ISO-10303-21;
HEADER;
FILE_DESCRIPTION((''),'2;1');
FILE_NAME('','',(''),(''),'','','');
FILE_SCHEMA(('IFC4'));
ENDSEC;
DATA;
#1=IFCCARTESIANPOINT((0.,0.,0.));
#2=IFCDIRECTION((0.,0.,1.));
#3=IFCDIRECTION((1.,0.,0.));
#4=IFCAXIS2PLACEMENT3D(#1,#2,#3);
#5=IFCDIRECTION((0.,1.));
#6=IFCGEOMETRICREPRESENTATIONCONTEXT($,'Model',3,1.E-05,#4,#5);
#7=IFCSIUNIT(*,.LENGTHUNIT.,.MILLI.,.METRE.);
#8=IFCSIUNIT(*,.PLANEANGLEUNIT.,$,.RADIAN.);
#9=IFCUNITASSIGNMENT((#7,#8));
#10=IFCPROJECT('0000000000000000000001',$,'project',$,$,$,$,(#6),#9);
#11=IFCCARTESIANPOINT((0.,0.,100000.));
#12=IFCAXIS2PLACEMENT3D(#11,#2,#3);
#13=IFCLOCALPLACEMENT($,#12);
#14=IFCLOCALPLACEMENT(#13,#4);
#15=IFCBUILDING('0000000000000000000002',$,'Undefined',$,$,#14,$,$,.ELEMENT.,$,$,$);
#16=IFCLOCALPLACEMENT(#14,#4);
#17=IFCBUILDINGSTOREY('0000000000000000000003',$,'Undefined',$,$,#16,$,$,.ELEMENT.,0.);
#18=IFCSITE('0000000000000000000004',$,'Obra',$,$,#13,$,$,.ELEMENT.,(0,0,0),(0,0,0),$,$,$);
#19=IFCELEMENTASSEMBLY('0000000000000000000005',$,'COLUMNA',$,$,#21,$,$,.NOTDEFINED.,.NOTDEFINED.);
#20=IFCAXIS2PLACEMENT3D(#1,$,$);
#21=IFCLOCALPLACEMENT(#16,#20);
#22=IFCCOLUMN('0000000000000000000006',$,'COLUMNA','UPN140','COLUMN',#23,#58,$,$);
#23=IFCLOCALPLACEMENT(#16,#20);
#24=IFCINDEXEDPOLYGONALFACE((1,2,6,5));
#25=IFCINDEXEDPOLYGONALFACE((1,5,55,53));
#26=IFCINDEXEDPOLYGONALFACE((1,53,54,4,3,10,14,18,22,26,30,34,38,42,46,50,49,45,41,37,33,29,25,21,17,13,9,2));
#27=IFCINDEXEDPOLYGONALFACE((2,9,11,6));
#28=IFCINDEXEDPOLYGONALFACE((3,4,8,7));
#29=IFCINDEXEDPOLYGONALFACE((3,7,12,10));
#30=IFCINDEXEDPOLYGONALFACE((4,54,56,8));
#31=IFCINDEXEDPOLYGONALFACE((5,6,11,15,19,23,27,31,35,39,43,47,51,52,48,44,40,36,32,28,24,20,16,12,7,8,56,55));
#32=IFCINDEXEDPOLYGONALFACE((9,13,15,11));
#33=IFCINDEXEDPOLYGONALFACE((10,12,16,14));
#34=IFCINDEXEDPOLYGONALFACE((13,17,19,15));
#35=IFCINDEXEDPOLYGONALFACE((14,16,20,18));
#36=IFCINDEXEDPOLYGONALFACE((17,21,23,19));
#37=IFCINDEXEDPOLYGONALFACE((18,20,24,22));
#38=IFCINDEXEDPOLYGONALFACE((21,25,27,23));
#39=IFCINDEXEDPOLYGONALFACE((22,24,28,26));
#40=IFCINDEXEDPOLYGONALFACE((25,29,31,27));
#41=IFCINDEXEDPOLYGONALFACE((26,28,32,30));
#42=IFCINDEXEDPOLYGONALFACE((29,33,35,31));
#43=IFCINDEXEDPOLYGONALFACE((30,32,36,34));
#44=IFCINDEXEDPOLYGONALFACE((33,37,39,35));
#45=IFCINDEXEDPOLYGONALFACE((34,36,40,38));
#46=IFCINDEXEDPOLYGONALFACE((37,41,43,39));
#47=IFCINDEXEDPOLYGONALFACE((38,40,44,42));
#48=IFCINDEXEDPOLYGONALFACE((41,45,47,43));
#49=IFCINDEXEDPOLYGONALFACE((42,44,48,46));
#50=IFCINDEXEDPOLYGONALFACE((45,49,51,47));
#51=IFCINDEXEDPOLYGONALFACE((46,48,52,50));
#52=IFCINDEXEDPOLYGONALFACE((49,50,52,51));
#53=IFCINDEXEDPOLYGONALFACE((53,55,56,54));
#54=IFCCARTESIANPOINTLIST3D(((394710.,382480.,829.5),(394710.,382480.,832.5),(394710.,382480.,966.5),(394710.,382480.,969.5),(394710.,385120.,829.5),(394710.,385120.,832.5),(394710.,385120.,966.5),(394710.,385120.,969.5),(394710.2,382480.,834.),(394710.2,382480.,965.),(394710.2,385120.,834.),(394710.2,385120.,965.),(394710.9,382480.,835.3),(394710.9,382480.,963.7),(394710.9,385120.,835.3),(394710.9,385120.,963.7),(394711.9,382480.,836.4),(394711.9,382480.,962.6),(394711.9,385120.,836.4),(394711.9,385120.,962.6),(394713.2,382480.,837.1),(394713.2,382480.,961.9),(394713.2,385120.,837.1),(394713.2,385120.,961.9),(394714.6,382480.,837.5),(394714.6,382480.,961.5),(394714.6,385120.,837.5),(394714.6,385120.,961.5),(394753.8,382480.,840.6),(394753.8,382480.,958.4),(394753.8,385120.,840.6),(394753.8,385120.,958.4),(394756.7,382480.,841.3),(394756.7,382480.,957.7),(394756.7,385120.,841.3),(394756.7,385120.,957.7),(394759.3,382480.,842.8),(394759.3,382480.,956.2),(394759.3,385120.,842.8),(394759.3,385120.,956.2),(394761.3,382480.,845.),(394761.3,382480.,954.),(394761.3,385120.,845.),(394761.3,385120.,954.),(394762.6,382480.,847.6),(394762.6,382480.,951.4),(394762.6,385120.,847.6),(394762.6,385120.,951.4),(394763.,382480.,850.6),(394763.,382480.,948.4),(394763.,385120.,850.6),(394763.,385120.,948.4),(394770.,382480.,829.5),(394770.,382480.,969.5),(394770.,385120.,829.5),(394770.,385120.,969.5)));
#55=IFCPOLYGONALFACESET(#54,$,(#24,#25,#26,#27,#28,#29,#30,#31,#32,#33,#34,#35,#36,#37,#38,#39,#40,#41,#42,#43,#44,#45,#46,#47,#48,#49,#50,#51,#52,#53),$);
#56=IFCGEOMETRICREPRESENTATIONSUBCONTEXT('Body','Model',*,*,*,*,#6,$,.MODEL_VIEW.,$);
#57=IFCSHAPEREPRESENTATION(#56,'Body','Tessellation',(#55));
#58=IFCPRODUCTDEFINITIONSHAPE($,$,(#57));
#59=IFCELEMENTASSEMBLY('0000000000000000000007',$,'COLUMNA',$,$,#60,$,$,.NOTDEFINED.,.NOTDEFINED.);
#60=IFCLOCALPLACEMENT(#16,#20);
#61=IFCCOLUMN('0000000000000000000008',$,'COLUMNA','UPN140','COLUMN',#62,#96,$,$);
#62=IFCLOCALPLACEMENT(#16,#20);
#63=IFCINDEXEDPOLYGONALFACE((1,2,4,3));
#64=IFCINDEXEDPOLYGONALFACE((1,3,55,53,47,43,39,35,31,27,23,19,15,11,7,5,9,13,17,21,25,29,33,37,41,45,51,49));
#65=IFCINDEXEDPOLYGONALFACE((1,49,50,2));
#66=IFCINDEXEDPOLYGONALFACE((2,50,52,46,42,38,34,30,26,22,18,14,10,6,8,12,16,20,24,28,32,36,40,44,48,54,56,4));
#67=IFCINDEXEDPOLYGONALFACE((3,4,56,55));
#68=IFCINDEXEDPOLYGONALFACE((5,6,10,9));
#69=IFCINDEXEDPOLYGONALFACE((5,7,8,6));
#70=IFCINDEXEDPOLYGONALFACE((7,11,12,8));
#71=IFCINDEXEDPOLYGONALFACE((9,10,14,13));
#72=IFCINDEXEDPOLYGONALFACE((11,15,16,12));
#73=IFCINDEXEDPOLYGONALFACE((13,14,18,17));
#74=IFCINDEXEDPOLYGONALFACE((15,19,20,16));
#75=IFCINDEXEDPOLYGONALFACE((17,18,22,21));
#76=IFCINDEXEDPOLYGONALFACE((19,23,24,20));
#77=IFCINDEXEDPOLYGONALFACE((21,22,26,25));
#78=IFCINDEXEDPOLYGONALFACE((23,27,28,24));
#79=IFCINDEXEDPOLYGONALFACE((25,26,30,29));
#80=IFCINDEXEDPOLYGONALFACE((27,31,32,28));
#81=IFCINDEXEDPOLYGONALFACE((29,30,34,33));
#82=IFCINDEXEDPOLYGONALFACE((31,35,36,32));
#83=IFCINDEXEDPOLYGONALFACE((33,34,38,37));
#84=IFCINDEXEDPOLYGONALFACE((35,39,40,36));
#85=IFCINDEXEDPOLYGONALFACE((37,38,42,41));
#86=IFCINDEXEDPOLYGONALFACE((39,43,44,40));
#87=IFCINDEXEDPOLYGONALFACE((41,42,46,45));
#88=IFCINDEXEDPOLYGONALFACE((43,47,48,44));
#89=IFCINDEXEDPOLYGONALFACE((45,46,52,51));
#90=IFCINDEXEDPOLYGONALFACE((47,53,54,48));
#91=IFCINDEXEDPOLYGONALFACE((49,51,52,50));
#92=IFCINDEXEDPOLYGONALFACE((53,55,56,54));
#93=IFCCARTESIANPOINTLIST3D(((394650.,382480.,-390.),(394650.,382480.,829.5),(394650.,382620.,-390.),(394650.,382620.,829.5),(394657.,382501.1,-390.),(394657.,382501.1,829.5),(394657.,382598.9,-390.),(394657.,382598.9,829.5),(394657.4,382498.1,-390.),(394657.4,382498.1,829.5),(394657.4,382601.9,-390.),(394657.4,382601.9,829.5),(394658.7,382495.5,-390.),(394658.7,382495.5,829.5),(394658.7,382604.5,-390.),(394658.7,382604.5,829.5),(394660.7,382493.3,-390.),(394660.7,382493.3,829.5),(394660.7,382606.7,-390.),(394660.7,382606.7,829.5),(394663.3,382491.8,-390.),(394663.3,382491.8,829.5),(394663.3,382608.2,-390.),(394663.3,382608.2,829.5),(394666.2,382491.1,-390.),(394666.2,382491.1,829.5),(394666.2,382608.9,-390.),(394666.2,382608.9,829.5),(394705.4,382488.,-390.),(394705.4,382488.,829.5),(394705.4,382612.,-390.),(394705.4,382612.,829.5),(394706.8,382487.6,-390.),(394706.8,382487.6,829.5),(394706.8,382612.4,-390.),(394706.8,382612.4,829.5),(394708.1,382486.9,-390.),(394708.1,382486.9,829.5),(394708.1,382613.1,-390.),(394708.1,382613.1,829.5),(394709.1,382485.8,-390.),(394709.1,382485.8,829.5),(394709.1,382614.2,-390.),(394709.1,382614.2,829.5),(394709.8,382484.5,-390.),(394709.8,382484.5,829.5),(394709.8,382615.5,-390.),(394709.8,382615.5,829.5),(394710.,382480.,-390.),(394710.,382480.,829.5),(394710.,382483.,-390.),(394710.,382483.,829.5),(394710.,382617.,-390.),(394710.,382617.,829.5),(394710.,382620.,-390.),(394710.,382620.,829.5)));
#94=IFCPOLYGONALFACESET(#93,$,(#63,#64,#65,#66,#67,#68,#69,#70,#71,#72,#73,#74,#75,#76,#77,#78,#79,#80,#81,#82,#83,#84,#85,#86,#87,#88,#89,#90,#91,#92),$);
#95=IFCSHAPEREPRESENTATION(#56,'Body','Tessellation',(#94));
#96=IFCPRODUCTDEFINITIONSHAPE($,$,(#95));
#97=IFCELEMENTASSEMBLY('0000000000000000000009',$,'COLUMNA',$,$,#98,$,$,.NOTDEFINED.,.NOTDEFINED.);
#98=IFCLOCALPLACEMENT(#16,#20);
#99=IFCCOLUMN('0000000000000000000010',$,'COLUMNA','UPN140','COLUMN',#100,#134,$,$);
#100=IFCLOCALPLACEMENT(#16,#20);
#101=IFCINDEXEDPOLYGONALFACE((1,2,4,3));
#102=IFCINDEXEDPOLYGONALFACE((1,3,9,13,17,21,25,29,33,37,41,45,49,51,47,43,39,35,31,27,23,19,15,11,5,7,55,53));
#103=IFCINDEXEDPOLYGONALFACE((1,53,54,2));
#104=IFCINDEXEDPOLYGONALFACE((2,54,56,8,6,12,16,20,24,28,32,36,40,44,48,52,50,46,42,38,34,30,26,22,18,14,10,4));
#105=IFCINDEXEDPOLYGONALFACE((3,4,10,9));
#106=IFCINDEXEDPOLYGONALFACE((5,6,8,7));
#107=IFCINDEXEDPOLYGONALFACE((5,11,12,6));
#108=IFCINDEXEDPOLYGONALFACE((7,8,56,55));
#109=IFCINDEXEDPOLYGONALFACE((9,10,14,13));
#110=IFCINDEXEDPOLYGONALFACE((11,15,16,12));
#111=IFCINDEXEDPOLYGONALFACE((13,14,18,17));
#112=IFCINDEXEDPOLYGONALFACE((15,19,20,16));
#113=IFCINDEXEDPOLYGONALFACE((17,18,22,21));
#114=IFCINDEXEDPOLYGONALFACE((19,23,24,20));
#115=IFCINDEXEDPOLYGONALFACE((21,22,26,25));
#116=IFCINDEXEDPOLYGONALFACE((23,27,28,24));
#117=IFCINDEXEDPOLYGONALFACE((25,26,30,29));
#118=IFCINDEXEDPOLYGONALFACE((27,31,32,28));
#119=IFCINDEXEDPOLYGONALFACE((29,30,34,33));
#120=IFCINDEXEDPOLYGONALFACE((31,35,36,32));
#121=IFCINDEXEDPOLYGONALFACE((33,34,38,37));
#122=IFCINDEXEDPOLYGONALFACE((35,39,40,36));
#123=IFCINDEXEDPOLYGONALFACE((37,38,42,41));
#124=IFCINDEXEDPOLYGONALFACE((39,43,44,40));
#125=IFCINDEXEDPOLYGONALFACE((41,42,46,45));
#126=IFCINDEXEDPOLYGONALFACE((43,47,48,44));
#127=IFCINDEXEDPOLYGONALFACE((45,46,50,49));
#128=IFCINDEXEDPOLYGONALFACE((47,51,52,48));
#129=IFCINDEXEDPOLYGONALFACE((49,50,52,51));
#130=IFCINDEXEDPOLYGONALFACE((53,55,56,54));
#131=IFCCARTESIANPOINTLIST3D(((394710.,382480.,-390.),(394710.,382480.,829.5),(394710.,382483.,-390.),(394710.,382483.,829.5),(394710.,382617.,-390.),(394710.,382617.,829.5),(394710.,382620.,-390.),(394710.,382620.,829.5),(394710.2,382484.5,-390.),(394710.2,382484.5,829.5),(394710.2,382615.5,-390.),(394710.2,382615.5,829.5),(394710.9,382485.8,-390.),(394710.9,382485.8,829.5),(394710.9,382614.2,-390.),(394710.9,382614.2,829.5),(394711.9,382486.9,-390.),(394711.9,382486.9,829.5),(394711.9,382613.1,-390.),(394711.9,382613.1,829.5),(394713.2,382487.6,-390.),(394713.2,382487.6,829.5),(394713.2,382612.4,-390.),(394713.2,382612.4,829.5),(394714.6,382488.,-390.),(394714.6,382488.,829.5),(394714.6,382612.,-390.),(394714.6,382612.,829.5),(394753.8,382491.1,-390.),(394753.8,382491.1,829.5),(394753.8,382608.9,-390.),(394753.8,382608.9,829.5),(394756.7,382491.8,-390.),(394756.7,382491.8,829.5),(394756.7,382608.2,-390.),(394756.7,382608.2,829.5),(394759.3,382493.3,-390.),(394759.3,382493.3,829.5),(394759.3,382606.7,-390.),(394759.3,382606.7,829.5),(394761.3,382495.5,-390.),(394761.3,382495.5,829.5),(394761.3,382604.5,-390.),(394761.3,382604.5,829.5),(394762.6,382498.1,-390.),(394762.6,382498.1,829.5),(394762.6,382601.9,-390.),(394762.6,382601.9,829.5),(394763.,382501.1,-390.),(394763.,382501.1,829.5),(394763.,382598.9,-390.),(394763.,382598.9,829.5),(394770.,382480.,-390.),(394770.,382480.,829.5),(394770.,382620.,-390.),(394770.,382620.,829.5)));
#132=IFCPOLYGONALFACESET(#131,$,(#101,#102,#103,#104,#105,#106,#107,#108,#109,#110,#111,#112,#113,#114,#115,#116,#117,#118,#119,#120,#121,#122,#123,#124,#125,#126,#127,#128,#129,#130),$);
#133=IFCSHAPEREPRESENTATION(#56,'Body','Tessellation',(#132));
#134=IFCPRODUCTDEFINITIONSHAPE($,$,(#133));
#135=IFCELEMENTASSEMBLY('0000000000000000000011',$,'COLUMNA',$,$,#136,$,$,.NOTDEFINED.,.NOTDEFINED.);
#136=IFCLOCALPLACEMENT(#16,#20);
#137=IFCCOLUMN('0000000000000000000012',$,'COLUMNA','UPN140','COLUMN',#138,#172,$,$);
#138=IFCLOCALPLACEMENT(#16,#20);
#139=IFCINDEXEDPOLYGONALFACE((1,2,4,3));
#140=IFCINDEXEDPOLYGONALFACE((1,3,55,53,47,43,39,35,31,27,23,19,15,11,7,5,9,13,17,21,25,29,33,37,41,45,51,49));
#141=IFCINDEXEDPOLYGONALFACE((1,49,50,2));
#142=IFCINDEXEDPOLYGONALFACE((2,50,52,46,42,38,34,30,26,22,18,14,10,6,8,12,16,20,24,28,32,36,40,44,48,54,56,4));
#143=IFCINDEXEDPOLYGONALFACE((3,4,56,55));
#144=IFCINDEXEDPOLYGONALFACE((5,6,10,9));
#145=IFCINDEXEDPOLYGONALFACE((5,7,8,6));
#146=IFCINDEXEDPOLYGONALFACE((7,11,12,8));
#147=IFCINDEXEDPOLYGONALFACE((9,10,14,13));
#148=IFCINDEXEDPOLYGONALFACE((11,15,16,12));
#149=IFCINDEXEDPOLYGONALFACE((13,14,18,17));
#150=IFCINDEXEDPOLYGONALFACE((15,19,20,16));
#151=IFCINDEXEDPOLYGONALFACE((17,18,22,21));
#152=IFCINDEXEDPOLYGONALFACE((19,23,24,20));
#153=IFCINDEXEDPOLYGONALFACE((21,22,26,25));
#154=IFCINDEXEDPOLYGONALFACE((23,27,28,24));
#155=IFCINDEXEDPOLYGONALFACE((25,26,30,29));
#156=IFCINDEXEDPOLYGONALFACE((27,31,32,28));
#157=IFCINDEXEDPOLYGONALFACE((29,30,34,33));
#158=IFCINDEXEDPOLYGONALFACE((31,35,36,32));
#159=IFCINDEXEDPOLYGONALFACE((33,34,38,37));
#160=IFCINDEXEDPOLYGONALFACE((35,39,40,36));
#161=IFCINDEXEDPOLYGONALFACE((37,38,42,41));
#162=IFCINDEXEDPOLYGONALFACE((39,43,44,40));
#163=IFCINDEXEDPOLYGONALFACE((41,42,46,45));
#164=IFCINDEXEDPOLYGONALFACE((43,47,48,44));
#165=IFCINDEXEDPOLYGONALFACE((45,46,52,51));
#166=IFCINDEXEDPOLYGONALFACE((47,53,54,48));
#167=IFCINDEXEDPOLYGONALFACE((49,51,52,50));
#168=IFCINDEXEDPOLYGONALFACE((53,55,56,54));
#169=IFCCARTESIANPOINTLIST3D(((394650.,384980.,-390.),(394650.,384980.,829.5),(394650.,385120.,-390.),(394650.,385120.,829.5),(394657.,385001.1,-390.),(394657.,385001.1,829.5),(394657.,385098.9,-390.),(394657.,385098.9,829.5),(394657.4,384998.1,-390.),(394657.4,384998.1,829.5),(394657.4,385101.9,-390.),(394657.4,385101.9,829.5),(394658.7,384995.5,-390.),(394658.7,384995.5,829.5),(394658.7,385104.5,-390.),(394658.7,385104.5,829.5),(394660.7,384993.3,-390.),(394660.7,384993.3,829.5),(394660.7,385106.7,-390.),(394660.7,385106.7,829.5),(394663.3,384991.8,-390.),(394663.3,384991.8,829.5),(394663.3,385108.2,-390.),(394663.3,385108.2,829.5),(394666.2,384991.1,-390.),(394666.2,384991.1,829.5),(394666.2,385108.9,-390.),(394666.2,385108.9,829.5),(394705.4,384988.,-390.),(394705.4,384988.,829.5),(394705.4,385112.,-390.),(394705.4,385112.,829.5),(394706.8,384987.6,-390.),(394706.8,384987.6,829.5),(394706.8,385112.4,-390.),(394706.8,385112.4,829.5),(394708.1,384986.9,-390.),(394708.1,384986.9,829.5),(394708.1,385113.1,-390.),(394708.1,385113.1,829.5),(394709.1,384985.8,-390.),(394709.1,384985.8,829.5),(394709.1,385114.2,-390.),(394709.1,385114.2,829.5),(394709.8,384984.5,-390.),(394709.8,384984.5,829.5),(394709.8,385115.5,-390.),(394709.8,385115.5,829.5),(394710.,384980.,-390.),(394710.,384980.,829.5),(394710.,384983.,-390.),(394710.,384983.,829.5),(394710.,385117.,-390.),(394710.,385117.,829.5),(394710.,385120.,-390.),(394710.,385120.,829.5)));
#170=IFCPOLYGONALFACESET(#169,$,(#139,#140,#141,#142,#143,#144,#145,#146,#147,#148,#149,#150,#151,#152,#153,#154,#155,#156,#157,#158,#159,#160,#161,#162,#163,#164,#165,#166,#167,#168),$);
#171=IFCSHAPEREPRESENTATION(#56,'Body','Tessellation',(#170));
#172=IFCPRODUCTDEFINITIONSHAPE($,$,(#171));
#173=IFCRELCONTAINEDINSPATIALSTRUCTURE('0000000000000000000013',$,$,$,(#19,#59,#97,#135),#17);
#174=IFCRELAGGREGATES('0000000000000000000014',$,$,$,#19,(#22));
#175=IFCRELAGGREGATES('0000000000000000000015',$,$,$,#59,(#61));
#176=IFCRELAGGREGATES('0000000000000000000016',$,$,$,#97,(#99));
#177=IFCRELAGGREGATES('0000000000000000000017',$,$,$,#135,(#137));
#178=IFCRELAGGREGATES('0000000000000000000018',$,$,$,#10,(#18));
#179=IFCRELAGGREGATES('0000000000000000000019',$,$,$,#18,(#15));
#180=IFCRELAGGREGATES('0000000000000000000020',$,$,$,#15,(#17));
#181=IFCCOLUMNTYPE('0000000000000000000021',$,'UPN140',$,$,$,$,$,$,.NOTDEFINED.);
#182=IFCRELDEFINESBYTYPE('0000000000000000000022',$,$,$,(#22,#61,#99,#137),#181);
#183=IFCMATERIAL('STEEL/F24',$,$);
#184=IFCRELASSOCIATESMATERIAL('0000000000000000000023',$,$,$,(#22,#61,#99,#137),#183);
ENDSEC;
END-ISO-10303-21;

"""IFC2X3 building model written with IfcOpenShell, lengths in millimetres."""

from ifc_helpers import new_model, si_unit, direction, frame, origin_with_axes, origin_2d_with_axis, place, context, subcontext, project, spatial, u_section, extrude, material, type_object, element, aggregate, save


model = new_model("IFC2X3")

# Units and contexts
model_context = context("Model", 3, precision=1e-05, world=origin_with_axes(), true_north=direction((0.0, 1.0)))
body_context = subcontext(model_context, "Body", "Model", "MODEL_VIEW")
ifc_project = project(units=[si_unit("LENGTHUNIT", "METRE", prefix="MILLI"), si_unit("PLANEANGLEUNIT", "RADIAN")], contexts=[model_context])

# Site, building, storey
site_placement = place(None, frame((0.0, 0.0, 100000.0), z_axis=(0.0, 0.0, 1.0), x_axis=(1.0, 0.0, 0.0)))
site = spatial("IfcSite", under=ifc_project, at=site_placement, Name="Obra", CompositionType="ELEMENT", RefLatitude=(0, 0, 0), RefLongitude=(0, 0, 0))
building_placement = place(site_placement, origin_with_axes())
building = spatial("IfcBuilding", under=site, at=building_placement, Name="Undefined", CompositionType="ELEMENT")
storey_placement = place(building_placement, origin_with_axes())
storey = spatial("IfcBuildingStorey", under=building, at=storey_placement, Name="Undefined", CompositionType="ELEMENT", Elevation=0.0)

# Element assemblies, columns
ifc_material_1 = material(Name="STEEL/F24")
column_type_1 = type_object("IfcColumnType", Name="UPN140", PredefinedType="NOTDEFINED")
assembly_1_placement = place(storey_placement, origin_with_axes())
assembly_1 = element("IfcElementAssembly", 1, at=assembly_1_placement, inside=storey, Name="COLUMNA", AssemblyPlace="NOTDEFINED", PredefinedType="NOTDEFINED")
column_1_placement = place(assembly_1_placement, frame((394740.0, 385120.0, 899.5), z_axis=(0.0, -1.0, 0.0), x_axis=(0.0, 0.0, 1.0)))
column_1 = element("IfcColumn", 2, at=column_1_placement, type_object=column_type_1, material=ifc_material_1, Name="COLUMNA", Description="UPN140", ObjectType="COLUMN", context=body_context, shape_type="SweptSolid", body=[
    extrude(u_section(Depth=140.0, FlangeWidth=60.0, WebThickness=7.0, FlangeThickness=10.0, FilletRadius=10.0, EdgeRadius=5.0, FlangeSlope=0.07983, at=origin_2d_with_axis()), frame((0.0, 0.0, 2640.0), z_axis=(0.0, 0.0, -1.0), x_axis=(0.0, 1.0, 0.0)), (0.0, 0.0, 1.0), 2640.0),
])
aggregate(assembly_1, [column_1])
assembly_2_placement = place(storey_placement, origin_with_axes())
assembly_2 = element("IfcElementAssembly", 3, at=assembly_2_placement, inside=storey, Name="COLUMNA", AssemblyPlace="NOTDEFINED", PredefinedType="NOTDEFINED")
column_2_placement = place(assembly_2_placement, frame((394680.0, 382550.0, -390.0), z_axis=(0.0, 0.0, 1.0), x_axis=(0.0, -1.0, 0.0)))
column_2 = element("IfcColumn", 4, at=column_2_placement, type_object=column_type_1, material=ifc_material_1, Name="COLUMNA", Description="UPN140", ObjectType="COLUMN", context=body_context, shape_type="SweptSolid", body=[
    extrude(u_section(Depth=140.0, FlangeWidth=60.0, WebThickness=7.0, FlangeThickness=10.0, FilletRadius=10.0, EdgeRadius=5.0, FlangeSlope=0.07983, at=origin_2d_with_axis()), frame((0.0, 0.0, 1219.5), z_axis=(0.0, 0.0, -1.0), x_axis=(0.0, 1.0, 0.0)), (0.0, 0.0, 1.0), 1219.5),
])
aggregate(assembly_2, [column_2])
assembly_3_placement = place(storey_placement, origin_with_axes())
assembly_3 = element("IfcElementAssembly", 5, at=assembly_3_placement, inside=storey, Name="COLUMNA", AssemblyPlace="NOTDEFINED", PredefinedType="NOTDEFINED")
column_3_placement = place(assembly_3_placement, frame((394740.0, 382550.0, -390.0), z_axis=(0.0, 0.0, 1.0), x_axis=(0.0, 1.0, 0.0)))
column_3 = element("IfcColumn", 6, at=column_3_placement, type_object=column_type_1, material=ifc_material_1, Name="COLUMNA", Description="UPN140", ObjectType="COLUMN", context=body_context, shape_type="SweptSolid", body=[
    extrude(u_section(Depth=140.0, FlangeWidth=60.0, WebThickness=7.0, FlangeThickness=10.0, FilletRadius=10.0, EdgeRadius=5.0, FlangeSlope=0.07983, at=origin_2d_with_axis()), frame((0.0, 0.0, 1219.5), z_axis=(0.0, 0.0, -1.0), x_axis=(0.0, 1.0, 0.0)), (0.0, 0.0, 1.0), 1219.5),
])
aggregate(assembly_3, [column_3])
assembly_4_placement = place(storey_placement, origin_with_axes())
assembly_4 = element("IfcElementAssembly", 7, at=assembly_4_placement, inside=storey, Name="COLUMNA", AssemblyPlace="NOTDEFINED", PredefinedType="NOTDEFINED")
column_4_placement = place(assembly_4_placement, frame((394680.0, 385050.0, -390.0), z_axis=(0.0, 0.0, 1.0), x_axis=(0.0, -1.0, 0.0)))
column_4 = element("IfcColumn", 8, at=column_4_placement, type_object=column_type_1, material=ifc_material_1, Name="COLUMNA", Description="UPN140", ObjectType="COLUMN", context=body_context, shape_type="SweptSolid", body=[
    extrude(u_section(Depth=140.0, FlangeWidth=60.0, WebThickness=7.0, FlangeThickness=10.0, FilletRadius=10.0, EdgeRadius=5.0, FlangeSlope=0.07983, at=origin_2d_with_axis()), frame((0.0, 0.0, 1219.5), z_axis=(0.0, 0.0, -1.0), x_axis=(0.0, 1.0, 0.0)), (0.0, 0.0, 1.0), 1219.5),
])
aggregate(assembly_4, [column_4])

save(model, "model.ifc")
